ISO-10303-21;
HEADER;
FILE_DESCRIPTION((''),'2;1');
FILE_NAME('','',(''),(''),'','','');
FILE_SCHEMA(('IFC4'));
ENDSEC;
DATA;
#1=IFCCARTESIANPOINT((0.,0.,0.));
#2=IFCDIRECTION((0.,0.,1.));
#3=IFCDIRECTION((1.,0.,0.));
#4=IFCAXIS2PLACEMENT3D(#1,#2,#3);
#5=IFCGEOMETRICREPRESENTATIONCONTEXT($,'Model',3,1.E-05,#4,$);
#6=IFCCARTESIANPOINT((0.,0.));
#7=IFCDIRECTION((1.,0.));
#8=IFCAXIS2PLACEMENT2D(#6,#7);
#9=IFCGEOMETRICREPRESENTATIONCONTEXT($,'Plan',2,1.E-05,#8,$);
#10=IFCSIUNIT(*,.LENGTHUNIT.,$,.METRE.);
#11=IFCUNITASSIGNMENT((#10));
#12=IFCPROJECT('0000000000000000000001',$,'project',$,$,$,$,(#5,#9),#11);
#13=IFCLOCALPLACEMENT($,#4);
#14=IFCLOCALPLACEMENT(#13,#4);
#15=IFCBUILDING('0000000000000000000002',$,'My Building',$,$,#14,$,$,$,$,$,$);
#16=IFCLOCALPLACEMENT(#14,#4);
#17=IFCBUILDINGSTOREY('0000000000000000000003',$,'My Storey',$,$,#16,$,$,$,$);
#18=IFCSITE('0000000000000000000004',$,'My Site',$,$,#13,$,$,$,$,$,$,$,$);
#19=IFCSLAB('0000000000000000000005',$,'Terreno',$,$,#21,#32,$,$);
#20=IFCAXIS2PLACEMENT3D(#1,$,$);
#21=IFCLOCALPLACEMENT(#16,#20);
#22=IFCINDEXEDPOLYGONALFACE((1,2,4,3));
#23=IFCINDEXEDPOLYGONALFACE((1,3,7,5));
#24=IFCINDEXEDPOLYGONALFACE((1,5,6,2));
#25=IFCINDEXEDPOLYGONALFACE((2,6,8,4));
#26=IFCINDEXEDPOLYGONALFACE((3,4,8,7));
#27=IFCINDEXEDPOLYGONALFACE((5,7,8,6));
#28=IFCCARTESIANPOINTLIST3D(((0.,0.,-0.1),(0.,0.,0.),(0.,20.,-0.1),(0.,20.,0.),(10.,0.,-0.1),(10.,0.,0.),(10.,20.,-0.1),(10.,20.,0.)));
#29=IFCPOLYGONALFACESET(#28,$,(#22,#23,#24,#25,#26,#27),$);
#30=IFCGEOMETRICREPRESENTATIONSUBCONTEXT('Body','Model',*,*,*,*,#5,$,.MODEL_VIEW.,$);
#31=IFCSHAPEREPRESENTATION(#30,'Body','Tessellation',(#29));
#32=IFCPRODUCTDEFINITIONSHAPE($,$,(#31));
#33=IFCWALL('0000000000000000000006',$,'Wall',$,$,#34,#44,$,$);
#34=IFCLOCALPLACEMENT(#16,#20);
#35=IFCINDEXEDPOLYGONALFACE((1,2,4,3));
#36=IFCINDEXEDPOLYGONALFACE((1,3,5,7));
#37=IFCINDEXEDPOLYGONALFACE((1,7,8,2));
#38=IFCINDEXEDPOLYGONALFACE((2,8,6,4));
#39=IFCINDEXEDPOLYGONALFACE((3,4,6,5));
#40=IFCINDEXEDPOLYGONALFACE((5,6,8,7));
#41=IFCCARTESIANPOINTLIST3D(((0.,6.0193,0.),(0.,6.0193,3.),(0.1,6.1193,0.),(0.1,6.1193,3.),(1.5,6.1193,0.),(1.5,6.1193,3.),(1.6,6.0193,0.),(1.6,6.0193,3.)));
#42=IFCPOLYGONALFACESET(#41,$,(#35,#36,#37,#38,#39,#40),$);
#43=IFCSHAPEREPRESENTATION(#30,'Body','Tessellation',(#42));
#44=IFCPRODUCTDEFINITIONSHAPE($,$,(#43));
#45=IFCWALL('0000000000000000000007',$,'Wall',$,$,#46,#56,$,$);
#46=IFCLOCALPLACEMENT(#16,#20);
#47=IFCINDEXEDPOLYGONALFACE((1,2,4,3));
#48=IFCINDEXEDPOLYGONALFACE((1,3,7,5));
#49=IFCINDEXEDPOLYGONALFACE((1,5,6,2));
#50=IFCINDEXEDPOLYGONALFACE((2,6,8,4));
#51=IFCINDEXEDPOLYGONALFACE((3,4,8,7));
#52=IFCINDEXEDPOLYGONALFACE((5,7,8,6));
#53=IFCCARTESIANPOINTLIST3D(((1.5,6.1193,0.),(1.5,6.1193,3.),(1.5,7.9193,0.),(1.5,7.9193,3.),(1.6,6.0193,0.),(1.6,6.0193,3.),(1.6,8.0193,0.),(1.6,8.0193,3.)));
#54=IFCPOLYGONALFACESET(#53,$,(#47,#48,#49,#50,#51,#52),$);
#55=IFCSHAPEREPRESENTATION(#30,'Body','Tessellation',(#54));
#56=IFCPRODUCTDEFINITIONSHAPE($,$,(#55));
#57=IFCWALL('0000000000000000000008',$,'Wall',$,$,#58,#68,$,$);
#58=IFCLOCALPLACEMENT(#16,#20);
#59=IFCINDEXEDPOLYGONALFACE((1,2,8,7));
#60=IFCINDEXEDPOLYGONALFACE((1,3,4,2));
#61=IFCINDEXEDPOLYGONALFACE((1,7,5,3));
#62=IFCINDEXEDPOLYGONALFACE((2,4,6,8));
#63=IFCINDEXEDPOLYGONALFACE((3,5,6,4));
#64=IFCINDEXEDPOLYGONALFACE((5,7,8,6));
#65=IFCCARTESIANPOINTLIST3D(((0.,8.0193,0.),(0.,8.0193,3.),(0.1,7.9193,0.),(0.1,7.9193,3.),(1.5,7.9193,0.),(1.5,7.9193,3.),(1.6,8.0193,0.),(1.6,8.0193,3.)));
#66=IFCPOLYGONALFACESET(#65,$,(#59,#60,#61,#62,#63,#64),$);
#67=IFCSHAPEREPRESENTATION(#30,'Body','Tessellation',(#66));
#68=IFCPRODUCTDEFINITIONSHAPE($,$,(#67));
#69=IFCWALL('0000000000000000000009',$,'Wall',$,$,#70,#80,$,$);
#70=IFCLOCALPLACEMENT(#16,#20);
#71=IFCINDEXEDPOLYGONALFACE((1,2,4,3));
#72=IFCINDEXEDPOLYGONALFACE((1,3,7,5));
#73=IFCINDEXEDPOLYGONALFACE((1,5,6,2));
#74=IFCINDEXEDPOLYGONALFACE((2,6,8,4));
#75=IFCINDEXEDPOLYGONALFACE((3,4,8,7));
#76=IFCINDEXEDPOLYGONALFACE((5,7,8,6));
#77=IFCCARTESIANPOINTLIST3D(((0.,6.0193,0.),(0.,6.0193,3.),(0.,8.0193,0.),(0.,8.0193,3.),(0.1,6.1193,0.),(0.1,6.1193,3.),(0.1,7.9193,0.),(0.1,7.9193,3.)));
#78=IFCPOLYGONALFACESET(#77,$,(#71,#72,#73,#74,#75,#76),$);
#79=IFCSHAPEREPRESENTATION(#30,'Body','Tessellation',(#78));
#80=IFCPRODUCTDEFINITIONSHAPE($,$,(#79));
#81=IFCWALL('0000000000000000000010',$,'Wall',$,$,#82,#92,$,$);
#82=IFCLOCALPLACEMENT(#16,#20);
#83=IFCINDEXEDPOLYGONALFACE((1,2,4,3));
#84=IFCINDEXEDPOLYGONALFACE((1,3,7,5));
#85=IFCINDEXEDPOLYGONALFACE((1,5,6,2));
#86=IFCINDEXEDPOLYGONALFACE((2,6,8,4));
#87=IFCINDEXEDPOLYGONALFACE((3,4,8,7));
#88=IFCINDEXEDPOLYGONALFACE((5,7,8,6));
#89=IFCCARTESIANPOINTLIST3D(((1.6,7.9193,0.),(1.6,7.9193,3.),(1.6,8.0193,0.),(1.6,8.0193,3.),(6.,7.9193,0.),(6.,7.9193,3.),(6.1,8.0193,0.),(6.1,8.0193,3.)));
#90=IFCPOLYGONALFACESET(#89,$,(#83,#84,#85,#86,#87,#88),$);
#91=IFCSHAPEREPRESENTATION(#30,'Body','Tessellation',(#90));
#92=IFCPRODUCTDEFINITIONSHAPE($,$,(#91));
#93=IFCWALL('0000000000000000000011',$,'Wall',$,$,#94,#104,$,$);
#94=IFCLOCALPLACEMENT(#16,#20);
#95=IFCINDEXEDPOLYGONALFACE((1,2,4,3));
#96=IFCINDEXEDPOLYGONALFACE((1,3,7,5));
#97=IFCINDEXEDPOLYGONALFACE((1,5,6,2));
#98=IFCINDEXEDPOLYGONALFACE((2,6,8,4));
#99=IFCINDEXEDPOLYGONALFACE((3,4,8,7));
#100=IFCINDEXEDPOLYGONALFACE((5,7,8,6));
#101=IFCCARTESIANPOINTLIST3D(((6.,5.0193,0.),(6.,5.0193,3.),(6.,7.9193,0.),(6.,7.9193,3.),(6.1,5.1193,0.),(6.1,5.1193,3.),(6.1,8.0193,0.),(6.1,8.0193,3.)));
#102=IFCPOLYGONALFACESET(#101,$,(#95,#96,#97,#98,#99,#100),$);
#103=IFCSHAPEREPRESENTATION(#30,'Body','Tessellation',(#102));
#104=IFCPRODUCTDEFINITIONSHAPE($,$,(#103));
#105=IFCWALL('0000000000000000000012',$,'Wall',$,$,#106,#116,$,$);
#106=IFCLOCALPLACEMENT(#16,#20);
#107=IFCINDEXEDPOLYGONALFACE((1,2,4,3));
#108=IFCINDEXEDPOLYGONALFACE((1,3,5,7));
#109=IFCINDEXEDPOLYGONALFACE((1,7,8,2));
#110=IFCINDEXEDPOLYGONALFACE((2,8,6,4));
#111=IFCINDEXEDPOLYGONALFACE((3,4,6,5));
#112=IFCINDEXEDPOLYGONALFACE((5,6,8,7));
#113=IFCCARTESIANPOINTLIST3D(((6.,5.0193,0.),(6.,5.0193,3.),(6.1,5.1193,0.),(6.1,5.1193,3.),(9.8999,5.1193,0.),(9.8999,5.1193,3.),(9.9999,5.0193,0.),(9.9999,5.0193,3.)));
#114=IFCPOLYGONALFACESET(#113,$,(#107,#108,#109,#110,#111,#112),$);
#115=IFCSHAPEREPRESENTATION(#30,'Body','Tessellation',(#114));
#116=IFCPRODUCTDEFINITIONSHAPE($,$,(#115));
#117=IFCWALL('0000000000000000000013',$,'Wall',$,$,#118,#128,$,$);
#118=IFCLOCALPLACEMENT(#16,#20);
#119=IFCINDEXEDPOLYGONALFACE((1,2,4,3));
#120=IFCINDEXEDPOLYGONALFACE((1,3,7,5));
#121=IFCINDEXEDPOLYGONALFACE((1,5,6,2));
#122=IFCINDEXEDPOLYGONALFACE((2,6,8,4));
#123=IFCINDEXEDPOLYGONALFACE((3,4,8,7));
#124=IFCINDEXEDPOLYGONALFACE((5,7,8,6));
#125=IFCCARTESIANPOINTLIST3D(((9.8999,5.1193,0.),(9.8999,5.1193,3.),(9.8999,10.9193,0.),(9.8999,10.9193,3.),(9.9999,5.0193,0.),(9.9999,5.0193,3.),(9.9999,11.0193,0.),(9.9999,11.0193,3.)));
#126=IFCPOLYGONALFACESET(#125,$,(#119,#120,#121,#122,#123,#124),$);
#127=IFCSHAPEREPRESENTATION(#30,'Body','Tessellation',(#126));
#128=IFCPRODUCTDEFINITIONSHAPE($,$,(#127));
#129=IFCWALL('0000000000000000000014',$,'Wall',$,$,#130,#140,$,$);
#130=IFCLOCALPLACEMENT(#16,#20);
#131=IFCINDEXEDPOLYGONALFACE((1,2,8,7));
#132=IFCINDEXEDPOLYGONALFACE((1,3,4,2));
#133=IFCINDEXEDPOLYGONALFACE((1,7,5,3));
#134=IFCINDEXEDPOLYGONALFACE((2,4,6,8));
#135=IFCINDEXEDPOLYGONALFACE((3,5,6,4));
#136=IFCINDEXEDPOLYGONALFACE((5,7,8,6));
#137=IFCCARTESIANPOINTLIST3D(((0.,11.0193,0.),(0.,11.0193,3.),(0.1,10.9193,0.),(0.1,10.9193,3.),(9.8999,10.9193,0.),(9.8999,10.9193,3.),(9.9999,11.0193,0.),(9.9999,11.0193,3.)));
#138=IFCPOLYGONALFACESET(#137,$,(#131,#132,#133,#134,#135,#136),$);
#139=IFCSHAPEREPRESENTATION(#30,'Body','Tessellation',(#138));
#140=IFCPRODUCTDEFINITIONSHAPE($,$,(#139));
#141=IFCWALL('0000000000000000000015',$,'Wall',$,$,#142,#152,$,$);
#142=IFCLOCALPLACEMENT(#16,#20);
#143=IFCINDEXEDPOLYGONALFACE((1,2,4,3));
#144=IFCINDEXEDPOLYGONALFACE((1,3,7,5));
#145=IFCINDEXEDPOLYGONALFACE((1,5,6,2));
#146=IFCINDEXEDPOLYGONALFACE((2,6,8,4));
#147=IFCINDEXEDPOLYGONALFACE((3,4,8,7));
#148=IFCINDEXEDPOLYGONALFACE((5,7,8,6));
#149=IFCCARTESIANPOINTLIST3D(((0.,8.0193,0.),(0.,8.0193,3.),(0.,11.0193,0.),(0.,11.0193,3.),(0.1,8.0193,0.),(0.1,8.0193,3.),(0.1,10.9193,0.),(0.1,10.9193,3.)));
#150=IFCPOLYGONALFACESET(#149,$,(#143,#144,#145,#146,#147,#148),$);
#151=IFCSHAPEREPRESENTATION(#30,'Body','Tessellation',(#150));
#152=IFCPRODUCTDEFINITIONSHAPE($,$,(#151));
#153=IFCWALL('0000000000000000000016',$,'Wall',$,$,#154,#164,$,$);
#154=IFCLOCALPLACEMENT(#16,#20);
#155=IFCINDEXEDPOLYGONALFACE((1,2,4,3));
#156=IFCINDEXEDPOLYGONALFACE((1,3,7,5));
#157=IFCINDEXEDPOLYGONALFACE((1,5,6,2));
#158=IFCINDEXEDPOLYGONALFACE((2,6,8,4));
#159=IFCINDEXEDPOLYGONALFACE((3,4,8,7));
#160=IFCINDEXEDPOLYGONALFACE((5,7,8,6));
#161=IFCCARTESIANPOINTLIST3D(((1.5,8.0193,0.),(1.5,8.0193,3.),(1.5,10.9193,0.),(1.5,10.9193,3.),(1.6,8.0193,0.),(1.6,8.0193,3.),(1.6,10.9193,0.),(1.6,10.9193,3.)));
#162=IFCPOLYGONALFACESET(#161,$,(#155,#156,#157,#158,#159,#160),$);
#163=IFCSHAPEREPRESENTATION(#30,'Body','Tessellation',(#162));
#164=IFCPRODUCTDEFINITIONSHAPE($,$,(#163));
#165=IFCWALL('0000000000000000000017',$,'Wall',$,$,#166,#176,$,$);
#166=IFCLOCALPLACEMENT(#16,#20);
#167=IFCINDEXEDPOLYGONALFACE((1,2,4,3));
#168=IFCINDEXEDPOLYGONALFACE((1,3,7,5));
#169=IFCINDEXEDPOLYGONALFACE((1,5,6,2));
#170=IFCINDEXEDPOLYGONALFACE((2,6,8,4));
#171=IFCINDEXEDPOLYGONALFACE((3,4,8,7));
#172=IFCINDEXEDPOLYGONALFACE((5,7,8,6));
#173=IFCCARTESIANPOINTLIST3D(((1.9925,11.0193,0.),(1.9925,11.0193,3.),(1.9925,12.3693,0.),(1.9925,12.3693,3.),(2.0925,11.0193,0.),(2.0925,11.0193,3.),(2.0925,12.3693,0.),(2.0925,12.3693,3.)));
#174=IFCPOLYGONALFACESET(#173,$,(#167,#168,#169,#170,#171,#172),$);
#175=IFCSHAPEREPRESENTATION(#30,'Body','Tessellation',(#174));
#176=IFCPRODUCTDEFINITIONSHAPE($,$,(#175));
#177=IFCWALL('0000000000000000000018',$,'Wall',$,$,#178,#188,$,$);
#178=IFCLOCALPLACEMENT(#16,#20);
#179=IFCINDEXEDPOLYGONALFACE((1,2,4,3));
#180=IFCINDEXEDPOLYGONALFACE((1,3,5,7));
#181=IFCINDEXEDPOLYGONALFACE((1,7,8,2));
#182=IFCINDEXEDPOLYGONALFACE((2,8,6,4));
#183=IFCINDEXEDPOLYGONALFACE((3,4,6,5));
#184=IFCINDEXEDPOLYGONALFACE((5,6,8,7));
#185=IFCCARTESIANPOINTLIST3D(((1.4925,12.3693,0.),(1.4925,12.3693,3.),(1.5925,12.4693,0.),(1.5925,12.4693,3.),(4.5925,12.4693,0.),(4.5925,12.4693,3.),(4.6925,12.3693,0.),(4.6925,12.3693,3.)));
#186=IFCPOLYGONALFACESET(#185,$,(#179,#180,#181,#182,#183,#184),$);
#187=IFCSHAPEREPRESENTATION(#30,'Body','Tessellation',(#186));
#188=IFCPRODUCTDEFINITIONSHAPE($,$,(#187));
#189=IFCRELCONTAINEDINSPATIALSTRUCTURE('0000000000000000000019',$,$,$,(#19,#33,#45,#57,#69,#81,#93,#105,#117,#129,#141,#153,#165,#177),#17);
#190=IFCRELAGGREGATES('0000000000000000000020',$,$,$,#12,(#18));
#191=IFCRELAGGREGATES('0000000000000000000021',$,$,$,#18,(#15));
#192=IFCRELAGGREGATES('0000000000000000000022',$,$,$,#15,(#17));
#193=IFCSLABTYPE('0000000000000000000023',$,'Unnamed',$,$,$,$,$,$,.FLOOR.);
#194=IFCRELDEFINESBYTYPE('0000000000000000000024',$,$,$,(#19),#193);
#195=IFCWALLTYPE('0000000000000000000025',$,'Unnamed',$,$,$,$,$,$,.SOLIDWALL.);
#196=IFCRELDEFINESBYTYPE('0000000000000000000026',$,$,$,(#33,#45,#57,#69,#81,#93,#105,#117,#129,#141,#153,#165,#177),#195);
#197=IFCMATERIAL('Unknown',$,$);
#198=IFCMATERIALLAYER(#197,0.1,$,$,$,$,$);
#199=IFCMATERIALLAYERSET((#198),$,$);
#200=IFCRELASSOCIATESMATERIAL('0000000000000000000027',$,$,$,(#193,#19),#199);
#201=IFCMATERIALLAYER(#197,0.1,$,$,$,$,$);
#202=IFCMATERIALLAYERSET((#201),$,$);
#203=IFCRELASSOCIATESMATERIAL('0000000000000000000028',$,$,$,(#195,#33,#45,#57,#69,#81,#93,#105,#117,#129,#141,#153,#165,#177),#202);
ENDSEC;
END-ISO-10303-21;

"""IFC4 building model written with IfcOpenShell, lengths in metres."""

from ifc_helpers import new_model, si_unit, frame, origin_with_axes, origin_2d_with_axis, place, context, subcontext, project, spatial, line, indexed_curve, outline, extrude, material, layer, layer_set, layer_usage, type_object, element, save


model = new_model("IFC4")

# Units and contexts
model_context = context("Model", 3, precision=1e-05, world=origin_with_axes())
plan_context = context("Plan", 2, precision=1e-05, world=origin_2d_with_axis())
body_context = subcontext(model_context, "Body", "Model", "MODEL_VIEW")
ifc_project = project(units=[si_unit("LENGTHUNIT", "METRE")], contexts=[model_context, plan_context])

# Site, building, storey
site_placement = place(None, origin_with_axes())
site = spatial("IfcSite", under=ifc_project, at=site_placement, Name="My Site")
building_placement = place(site_placement, origin_with_axes())
building = spatial("IfcBuilding", under=site, at=building_placement, Name="My Building")
storey_placement = place(building_placement, origin_with_axes())
storey = spatial("IfcBuildingStorey", under=building, at=storey_placement, Name="My Storey")

# Slab
ifc_material = material(Name="Unknown")
ifc_layer_1 = layer(ifc_material, 0.1)
ifc_layer_set_1 = layer_set([ifc_layer_1])
ifc_layer_usage_1 = layer_usage(ifc_layer_set_1, "AXIS3", "POSITIVE", -0.1)
slab_type = type_object("IfcSlabType", Name="Unnamed", PredefinedType="FLOOR", material=ifc_layer_set_1)
slab_placement = place(storey_placement, origin_with_axes())
element("IfcSlab", 1, at=slab_placement, inside=storey, type_object=slab_type, material=ifc_layer_usage_1, Name="Terreno", context=body_context, shape_type="SweptSolid", body=[
    extrude(outline(indexed_curve([(0.0, 0.0), (10.0, 0.0), (10.0, 20.0), (0.0, 20.0), (0.0, 0.0)])), frame((0.0, 0.0, -0.1), z_axis=(0.0, 0.0, 1.0), x_axis=(1.0, 0.0, 0.0)), (0.0, 0.0, 1.0), 0.1),
])

# Walls
ifc_layer_2 = layer(ifc_material, 0.1)
ifc_layer_set_2 = layer_set([ifc_layer_2])
ifc_layer_usage_2 = layer_usage(ifc_layer_set_2, "AXIS2", "POSITIVE", 0.0)
wall_type = type_object("IfcWallType", Name="Unnamed", PredefinedType="SOLIDWALL", material=ifc_layer_set_2)
wall_1_placement = place(storey_placement, frame((0.0, 6.0193, 0.0), z_axis=(0.0, 0.0, 1.0), x_axis=(1.0, 0.0, 0.0)))
element("IfcWall", 2, at=wall_1_placement, inside=storey, type_object=wall_type, material=ifc_layer_usage_2, Name="Wall", context=body_context, shape_type="SweptSolid", body=[
    extrude(outline(indexed_curve([(0.0, 0.0), (0.1, 0.1), (1.5, 0.1), (1.6, 0.0)], segments=[line(1, 2, 3, 4, 1)])), origin_with_axes(), (0.0, 0.0, 1.0), 3.0),
])
ifc_layer_usage_3 = layer_usage(ifc_layer_set_2, "AXIS2", "POSITIVE", 0.0)
wall_2_placement = place(storey_placement, frame((1.6, 6.0193, 0.0), z_axis=(0.0, 0.0, 1.0), x_axis=(0.0, 1.0, 0.0)))
element("IfcWall", 3, at=wall_2_placement, inside=storey, type_object=wall_type, material=ifc_layer_usage_3, Name="Wall", context=body_context, shape_type="SweptSolid", body=[
    extrude(outline(indexed_curve([(0.0, 0.0), (0.1, 0.1), (1.9, 0.1), (2.0, 0.0)], segments=[line(1, 2, 3, 4, 1)])), origin_with_axes(), (0.0, 0.0, 1.0), 3.0),
])
ifc_layer_usage_4 = layer_usage(ifc_layer_set_2, "AXIS2", "POSITIVE", 0.0)
wall_3_placement = place(storey_placement, frame((1.6, 8.0193, 0.0), z_axis=(0.0, 0.0, 1.0), x_axis=(-1.0, 0.0, 0.0)))
element("IfcWall", 4, at=wall_3_placement, inside=storey, type_object=wall_type, material=ifc_layer_usage_4, Name="Wall", context=body_context, shape_type="SweptSolid", body=[
    extrude(outline(indexed_curve([(0.0, 0.0), (0.1, 0.1), (1.5, 0.1), (1.6, 0.0)], segments=[line(1, 2, 3, 4, 1)])), origin_with_axes(), (0.0, 0.0, 1.0), 3.0),
])
ifc_layer_usage_5 = layer_usage(ifc_layer_set_2, "AXIS2", "POSITIVE", 0.0)
wall_4_placement = place(storey_placement, frame((0.0, 8.0193, 0.0), z_axis=(0.0, 0.0, 1.0), x_axis=(0.0, -1.0, 0.0)))
element("IfcWall", 5, at=wall_4_placement, inside=storey, type_object=wall_type, material=ifc_layer_usage_5, Name="Wall", context=body_context, shape_type="SweptSolid", body=[
    extrude(outline(indexed_curve([(0.0, 0.0), (0.1, 0.1), (1.9, 0.1), (2.0, 0.0)], segments=[line(1, 2, 3, 4, 1)])), origin_with_axes(), (0.0, 0.0, 1.0), 3.0),
])
ifc_layer_usage_6 = layer_usage(ifc_layer_set_2, "AXIS2", "POSITIVE", 0.0)
wall_5_placement = place(storey_placement, frame((1.6, 7.9193, 0.0), z_axis=(0.0, 0.0, 1.0), x_axis=(1.0, 0.0, 0.0)))
element("IfcWall", 6, at=wall_5_placement, inside=storey, type_object=wall_type, material=ifc_layer_usage_6, Name="Wall", context=body_context, shape_type="SweptSolid", body=[
    extrude(outline(indexed_curve([(0.0, 0.0), (0.0, 0.1), (4.5, 0.1), (4.4, 0.0)], segments=[line(1, 2, 3, 4, 1)])), origin_with_axes(), (0.0, 0.0, 1.0), 3.0),
])
ifc_layer_usage_7 = layer_usage(ifc_layer_set_2, "AXIS2", "POSITIVE", 0.0)
wall_6_placement = place(storey_placement, frame((6.0, 7.9193, 0.0), z_axis=(0.0, 0.0, 1.0), x_axis=(0.0, -1.0, 0.0)))
element("IfcWall", 7, at=wall_6_placement, inside=storey, type_object=wall_type, material=ifc_layer_usage_7, Name="Wall", context=body_context, shape_type="SweptSolid", body=[
    extrude(outline(indexed_curve([(0.0, 0.0), (-0.1, 0.1), (2.8, 0.1), (2.9, 0.0)], segments=[line(1, 2, 3, 4, 1)])), origin_with_axes(), (0.0, 0.0, 1.0), 3.0),
])
ifc_layer_usage_8 = layer_usage(ifc_layer_set_2, "AXIS2", "POSITIVE", 0.0)
wall_7_placement = place(storey_placement, frame((6.0, 5.0193, 0.0), z_axis=(0.0, 0.0, 1.0), x_axis=(1.0, 0.0, 0.0)))
element("IfcWall", 8, at=wall_7_placement, inside=storey, type_object=wall_type, material=ifc_layer_usage_8, Name="Wall", context=body_context, shape_type="SweptSolid", body=[
    extrude(outline(indexed_curve([(0.0, 0.0), (0.1, 0.1), (3.8999, 0.1), (3.9999, 0.0)], segments=[line(1, 2, 3, 4, 1)])), origin_with_axes(), (0.0, 0.0, 1.0), 3.0),
])
ifc_layer_usage_9 = layer_usage(ifc_layer_set_2, "AXIS2", "POSITIVE", 0.0)
wall_8_placement = place(storey_placement, frame((9.9999, 5.0193, 0.0), z_axis=(0.0, 0.0, 1.0), x_axis=(0.0, 1.0, 0.0)))
element("IfcWall", 9, at=wall_8_placement, inside=storey, type_object=wall_type, material=ifc_layer_usage_9, Name="Wall", context=body_context, shape_type="SweptSolid", body=[
    extrude(outline(indexed_curve([(0.0, 0.0), (0.1, 0.1), (5.9, 0.1), (6.0, 0.0)], segments=[line(1, 2, 3, 4, 1)])), origin_with_axes(), (0.0, 0.0, 1.0), 3.0),
])
ifc_layer_usage_10 = layer_usage(ifc_layer_set_2, "AXIS2", "POSITIVE", 0.0)
wall_9_placement = place(storey_placement, frame((9.9999, 11.0193, 0.0), z_axis=(0.0, 0.0, 1.0), x_axis=(-1.0, 0.0, 0.0)))
element("IfcWall", 10, at=wall_9_placement, inside=storey, type_object=wall_type, material=ifc_layer_usage_10, Name="Wall", context=body_context, shape_type="SweptSolid", body=[
    extrude(outline(indexed_curve([(0.0, 0.0), (0.1, 0.1), (9.8999, 0.1), (9.9999, 0.0)], segments=[line(1, 2, 3, 4, 1)])), origin_with_axes(), (0.0, 0.0, 1.0), 3.0),
])
ifc_layer_usage_11 = layer_usage(ifc_layer_set_2, "AXIS2", "POSITIVE", 0.0)
wall_10_placement = place(storey_placement, frame((0.0, 11.0193, 0.0), z_axis=(0.0, 0.0, 1.0), x_axis=(0.0, -1.0, 0.0)))
element("IfcWall", 11, at=wall_10_placement, inside=storey, type_object=wall_type, material=ifc_layer_usage_11, Name="Wall", context=body_context, shape_type="SweptSolid", body=[
    extrude(outline(indexed_curve([(0.0, 0.0), (0.1, 0.1), (3.0, 0.1), (3.0, 0.0)], segments=[line(1, 2, 3, 4, 1)])), origin_with_axes(), (0.0, 0.0, 1.0), 3.0),
])
ifc_layer_usage_12 = layer_usage(ifc_layer_set_2, "AXIS2", "POSITIVE", 0.0)
wall_11_placement = place(storey_placement, frame((1.6, 8.0193, 0.0), z_axis=(0.0, 0.0, 1.0), x_axis=(0.0, 1.0, 0.0)))
element("IfcWall", 12, at=wall_11_placement, inside=storey, type_object=wall_type, material=ifc_layer_usage_12, Name="Wall", context=body_context, shape_type="SweptSolid", body=[
    extrude(outline(indexed_curve([(0.0, 0.0), (0.0, 0.1), (2.9, 0.1), (2.9, 0.0)], segments=[line(1, 2, 3, 4, 1)])), origin_with_axes(), (0.0, 0.0, 1.0), 3.0),
])
ifc_layer_usage_13 = layer_usage(ifc_layer_set_2, "AXIS2", "POSITIVE", 0.0)
wall_12_placement = place(storey_placement, frame((2.0925, 11.0193, 0.0), z_axis=(0.0, 0.0, 1.0), x_axis=(0.0, 1.0, 0.0)))
element("IfcWall", 13, at=wall_12_placement, inside=storey, type_object=wall_type, material=ifc_layer_usage_13, Name="Wall", context=body_context, shape_type="SweptSolid", body=[
    extrude(outline(indexed_curve([(0.0, 0.0), (0.0, 0.1), (1.35, 0.1), (1.35, 0.0)], segments=[line(1, 2, 3, 4, 1)])), origin_with_axes(), (0.0, 0.0, 1.0), 3.0),
])
ifc_layer_usage_14 = layer_usage(ifc_layer_set_2, "AXIS2", "POSITIVE", 0.0)
wall_13_placement = place(storey_placement, frame((1.5925, 12.3693, 0.0), z_axis=(0.0, 0.0, 1.0), x_axis=(1.0, 0.0, 0.0)))
element("IfcWall", 14, at=wall_13_placement, inside=storey, type_object=wall_type, material=ifc_layer_usage_14, Name="Wall", context=body_context, shape_type="SweptSolid", body=[
    extrude(outline(indexed_curve([(-0.1, 0.0), (0.0, 0.1), (3.0, 0.1), (3.1, 0.0)], segments=[line(1, 2, 3, 4, 1)])), origin_with_axes(), (0.0, 0.0, 1.0), 3.0),
])

save(model, "model.ifc")
